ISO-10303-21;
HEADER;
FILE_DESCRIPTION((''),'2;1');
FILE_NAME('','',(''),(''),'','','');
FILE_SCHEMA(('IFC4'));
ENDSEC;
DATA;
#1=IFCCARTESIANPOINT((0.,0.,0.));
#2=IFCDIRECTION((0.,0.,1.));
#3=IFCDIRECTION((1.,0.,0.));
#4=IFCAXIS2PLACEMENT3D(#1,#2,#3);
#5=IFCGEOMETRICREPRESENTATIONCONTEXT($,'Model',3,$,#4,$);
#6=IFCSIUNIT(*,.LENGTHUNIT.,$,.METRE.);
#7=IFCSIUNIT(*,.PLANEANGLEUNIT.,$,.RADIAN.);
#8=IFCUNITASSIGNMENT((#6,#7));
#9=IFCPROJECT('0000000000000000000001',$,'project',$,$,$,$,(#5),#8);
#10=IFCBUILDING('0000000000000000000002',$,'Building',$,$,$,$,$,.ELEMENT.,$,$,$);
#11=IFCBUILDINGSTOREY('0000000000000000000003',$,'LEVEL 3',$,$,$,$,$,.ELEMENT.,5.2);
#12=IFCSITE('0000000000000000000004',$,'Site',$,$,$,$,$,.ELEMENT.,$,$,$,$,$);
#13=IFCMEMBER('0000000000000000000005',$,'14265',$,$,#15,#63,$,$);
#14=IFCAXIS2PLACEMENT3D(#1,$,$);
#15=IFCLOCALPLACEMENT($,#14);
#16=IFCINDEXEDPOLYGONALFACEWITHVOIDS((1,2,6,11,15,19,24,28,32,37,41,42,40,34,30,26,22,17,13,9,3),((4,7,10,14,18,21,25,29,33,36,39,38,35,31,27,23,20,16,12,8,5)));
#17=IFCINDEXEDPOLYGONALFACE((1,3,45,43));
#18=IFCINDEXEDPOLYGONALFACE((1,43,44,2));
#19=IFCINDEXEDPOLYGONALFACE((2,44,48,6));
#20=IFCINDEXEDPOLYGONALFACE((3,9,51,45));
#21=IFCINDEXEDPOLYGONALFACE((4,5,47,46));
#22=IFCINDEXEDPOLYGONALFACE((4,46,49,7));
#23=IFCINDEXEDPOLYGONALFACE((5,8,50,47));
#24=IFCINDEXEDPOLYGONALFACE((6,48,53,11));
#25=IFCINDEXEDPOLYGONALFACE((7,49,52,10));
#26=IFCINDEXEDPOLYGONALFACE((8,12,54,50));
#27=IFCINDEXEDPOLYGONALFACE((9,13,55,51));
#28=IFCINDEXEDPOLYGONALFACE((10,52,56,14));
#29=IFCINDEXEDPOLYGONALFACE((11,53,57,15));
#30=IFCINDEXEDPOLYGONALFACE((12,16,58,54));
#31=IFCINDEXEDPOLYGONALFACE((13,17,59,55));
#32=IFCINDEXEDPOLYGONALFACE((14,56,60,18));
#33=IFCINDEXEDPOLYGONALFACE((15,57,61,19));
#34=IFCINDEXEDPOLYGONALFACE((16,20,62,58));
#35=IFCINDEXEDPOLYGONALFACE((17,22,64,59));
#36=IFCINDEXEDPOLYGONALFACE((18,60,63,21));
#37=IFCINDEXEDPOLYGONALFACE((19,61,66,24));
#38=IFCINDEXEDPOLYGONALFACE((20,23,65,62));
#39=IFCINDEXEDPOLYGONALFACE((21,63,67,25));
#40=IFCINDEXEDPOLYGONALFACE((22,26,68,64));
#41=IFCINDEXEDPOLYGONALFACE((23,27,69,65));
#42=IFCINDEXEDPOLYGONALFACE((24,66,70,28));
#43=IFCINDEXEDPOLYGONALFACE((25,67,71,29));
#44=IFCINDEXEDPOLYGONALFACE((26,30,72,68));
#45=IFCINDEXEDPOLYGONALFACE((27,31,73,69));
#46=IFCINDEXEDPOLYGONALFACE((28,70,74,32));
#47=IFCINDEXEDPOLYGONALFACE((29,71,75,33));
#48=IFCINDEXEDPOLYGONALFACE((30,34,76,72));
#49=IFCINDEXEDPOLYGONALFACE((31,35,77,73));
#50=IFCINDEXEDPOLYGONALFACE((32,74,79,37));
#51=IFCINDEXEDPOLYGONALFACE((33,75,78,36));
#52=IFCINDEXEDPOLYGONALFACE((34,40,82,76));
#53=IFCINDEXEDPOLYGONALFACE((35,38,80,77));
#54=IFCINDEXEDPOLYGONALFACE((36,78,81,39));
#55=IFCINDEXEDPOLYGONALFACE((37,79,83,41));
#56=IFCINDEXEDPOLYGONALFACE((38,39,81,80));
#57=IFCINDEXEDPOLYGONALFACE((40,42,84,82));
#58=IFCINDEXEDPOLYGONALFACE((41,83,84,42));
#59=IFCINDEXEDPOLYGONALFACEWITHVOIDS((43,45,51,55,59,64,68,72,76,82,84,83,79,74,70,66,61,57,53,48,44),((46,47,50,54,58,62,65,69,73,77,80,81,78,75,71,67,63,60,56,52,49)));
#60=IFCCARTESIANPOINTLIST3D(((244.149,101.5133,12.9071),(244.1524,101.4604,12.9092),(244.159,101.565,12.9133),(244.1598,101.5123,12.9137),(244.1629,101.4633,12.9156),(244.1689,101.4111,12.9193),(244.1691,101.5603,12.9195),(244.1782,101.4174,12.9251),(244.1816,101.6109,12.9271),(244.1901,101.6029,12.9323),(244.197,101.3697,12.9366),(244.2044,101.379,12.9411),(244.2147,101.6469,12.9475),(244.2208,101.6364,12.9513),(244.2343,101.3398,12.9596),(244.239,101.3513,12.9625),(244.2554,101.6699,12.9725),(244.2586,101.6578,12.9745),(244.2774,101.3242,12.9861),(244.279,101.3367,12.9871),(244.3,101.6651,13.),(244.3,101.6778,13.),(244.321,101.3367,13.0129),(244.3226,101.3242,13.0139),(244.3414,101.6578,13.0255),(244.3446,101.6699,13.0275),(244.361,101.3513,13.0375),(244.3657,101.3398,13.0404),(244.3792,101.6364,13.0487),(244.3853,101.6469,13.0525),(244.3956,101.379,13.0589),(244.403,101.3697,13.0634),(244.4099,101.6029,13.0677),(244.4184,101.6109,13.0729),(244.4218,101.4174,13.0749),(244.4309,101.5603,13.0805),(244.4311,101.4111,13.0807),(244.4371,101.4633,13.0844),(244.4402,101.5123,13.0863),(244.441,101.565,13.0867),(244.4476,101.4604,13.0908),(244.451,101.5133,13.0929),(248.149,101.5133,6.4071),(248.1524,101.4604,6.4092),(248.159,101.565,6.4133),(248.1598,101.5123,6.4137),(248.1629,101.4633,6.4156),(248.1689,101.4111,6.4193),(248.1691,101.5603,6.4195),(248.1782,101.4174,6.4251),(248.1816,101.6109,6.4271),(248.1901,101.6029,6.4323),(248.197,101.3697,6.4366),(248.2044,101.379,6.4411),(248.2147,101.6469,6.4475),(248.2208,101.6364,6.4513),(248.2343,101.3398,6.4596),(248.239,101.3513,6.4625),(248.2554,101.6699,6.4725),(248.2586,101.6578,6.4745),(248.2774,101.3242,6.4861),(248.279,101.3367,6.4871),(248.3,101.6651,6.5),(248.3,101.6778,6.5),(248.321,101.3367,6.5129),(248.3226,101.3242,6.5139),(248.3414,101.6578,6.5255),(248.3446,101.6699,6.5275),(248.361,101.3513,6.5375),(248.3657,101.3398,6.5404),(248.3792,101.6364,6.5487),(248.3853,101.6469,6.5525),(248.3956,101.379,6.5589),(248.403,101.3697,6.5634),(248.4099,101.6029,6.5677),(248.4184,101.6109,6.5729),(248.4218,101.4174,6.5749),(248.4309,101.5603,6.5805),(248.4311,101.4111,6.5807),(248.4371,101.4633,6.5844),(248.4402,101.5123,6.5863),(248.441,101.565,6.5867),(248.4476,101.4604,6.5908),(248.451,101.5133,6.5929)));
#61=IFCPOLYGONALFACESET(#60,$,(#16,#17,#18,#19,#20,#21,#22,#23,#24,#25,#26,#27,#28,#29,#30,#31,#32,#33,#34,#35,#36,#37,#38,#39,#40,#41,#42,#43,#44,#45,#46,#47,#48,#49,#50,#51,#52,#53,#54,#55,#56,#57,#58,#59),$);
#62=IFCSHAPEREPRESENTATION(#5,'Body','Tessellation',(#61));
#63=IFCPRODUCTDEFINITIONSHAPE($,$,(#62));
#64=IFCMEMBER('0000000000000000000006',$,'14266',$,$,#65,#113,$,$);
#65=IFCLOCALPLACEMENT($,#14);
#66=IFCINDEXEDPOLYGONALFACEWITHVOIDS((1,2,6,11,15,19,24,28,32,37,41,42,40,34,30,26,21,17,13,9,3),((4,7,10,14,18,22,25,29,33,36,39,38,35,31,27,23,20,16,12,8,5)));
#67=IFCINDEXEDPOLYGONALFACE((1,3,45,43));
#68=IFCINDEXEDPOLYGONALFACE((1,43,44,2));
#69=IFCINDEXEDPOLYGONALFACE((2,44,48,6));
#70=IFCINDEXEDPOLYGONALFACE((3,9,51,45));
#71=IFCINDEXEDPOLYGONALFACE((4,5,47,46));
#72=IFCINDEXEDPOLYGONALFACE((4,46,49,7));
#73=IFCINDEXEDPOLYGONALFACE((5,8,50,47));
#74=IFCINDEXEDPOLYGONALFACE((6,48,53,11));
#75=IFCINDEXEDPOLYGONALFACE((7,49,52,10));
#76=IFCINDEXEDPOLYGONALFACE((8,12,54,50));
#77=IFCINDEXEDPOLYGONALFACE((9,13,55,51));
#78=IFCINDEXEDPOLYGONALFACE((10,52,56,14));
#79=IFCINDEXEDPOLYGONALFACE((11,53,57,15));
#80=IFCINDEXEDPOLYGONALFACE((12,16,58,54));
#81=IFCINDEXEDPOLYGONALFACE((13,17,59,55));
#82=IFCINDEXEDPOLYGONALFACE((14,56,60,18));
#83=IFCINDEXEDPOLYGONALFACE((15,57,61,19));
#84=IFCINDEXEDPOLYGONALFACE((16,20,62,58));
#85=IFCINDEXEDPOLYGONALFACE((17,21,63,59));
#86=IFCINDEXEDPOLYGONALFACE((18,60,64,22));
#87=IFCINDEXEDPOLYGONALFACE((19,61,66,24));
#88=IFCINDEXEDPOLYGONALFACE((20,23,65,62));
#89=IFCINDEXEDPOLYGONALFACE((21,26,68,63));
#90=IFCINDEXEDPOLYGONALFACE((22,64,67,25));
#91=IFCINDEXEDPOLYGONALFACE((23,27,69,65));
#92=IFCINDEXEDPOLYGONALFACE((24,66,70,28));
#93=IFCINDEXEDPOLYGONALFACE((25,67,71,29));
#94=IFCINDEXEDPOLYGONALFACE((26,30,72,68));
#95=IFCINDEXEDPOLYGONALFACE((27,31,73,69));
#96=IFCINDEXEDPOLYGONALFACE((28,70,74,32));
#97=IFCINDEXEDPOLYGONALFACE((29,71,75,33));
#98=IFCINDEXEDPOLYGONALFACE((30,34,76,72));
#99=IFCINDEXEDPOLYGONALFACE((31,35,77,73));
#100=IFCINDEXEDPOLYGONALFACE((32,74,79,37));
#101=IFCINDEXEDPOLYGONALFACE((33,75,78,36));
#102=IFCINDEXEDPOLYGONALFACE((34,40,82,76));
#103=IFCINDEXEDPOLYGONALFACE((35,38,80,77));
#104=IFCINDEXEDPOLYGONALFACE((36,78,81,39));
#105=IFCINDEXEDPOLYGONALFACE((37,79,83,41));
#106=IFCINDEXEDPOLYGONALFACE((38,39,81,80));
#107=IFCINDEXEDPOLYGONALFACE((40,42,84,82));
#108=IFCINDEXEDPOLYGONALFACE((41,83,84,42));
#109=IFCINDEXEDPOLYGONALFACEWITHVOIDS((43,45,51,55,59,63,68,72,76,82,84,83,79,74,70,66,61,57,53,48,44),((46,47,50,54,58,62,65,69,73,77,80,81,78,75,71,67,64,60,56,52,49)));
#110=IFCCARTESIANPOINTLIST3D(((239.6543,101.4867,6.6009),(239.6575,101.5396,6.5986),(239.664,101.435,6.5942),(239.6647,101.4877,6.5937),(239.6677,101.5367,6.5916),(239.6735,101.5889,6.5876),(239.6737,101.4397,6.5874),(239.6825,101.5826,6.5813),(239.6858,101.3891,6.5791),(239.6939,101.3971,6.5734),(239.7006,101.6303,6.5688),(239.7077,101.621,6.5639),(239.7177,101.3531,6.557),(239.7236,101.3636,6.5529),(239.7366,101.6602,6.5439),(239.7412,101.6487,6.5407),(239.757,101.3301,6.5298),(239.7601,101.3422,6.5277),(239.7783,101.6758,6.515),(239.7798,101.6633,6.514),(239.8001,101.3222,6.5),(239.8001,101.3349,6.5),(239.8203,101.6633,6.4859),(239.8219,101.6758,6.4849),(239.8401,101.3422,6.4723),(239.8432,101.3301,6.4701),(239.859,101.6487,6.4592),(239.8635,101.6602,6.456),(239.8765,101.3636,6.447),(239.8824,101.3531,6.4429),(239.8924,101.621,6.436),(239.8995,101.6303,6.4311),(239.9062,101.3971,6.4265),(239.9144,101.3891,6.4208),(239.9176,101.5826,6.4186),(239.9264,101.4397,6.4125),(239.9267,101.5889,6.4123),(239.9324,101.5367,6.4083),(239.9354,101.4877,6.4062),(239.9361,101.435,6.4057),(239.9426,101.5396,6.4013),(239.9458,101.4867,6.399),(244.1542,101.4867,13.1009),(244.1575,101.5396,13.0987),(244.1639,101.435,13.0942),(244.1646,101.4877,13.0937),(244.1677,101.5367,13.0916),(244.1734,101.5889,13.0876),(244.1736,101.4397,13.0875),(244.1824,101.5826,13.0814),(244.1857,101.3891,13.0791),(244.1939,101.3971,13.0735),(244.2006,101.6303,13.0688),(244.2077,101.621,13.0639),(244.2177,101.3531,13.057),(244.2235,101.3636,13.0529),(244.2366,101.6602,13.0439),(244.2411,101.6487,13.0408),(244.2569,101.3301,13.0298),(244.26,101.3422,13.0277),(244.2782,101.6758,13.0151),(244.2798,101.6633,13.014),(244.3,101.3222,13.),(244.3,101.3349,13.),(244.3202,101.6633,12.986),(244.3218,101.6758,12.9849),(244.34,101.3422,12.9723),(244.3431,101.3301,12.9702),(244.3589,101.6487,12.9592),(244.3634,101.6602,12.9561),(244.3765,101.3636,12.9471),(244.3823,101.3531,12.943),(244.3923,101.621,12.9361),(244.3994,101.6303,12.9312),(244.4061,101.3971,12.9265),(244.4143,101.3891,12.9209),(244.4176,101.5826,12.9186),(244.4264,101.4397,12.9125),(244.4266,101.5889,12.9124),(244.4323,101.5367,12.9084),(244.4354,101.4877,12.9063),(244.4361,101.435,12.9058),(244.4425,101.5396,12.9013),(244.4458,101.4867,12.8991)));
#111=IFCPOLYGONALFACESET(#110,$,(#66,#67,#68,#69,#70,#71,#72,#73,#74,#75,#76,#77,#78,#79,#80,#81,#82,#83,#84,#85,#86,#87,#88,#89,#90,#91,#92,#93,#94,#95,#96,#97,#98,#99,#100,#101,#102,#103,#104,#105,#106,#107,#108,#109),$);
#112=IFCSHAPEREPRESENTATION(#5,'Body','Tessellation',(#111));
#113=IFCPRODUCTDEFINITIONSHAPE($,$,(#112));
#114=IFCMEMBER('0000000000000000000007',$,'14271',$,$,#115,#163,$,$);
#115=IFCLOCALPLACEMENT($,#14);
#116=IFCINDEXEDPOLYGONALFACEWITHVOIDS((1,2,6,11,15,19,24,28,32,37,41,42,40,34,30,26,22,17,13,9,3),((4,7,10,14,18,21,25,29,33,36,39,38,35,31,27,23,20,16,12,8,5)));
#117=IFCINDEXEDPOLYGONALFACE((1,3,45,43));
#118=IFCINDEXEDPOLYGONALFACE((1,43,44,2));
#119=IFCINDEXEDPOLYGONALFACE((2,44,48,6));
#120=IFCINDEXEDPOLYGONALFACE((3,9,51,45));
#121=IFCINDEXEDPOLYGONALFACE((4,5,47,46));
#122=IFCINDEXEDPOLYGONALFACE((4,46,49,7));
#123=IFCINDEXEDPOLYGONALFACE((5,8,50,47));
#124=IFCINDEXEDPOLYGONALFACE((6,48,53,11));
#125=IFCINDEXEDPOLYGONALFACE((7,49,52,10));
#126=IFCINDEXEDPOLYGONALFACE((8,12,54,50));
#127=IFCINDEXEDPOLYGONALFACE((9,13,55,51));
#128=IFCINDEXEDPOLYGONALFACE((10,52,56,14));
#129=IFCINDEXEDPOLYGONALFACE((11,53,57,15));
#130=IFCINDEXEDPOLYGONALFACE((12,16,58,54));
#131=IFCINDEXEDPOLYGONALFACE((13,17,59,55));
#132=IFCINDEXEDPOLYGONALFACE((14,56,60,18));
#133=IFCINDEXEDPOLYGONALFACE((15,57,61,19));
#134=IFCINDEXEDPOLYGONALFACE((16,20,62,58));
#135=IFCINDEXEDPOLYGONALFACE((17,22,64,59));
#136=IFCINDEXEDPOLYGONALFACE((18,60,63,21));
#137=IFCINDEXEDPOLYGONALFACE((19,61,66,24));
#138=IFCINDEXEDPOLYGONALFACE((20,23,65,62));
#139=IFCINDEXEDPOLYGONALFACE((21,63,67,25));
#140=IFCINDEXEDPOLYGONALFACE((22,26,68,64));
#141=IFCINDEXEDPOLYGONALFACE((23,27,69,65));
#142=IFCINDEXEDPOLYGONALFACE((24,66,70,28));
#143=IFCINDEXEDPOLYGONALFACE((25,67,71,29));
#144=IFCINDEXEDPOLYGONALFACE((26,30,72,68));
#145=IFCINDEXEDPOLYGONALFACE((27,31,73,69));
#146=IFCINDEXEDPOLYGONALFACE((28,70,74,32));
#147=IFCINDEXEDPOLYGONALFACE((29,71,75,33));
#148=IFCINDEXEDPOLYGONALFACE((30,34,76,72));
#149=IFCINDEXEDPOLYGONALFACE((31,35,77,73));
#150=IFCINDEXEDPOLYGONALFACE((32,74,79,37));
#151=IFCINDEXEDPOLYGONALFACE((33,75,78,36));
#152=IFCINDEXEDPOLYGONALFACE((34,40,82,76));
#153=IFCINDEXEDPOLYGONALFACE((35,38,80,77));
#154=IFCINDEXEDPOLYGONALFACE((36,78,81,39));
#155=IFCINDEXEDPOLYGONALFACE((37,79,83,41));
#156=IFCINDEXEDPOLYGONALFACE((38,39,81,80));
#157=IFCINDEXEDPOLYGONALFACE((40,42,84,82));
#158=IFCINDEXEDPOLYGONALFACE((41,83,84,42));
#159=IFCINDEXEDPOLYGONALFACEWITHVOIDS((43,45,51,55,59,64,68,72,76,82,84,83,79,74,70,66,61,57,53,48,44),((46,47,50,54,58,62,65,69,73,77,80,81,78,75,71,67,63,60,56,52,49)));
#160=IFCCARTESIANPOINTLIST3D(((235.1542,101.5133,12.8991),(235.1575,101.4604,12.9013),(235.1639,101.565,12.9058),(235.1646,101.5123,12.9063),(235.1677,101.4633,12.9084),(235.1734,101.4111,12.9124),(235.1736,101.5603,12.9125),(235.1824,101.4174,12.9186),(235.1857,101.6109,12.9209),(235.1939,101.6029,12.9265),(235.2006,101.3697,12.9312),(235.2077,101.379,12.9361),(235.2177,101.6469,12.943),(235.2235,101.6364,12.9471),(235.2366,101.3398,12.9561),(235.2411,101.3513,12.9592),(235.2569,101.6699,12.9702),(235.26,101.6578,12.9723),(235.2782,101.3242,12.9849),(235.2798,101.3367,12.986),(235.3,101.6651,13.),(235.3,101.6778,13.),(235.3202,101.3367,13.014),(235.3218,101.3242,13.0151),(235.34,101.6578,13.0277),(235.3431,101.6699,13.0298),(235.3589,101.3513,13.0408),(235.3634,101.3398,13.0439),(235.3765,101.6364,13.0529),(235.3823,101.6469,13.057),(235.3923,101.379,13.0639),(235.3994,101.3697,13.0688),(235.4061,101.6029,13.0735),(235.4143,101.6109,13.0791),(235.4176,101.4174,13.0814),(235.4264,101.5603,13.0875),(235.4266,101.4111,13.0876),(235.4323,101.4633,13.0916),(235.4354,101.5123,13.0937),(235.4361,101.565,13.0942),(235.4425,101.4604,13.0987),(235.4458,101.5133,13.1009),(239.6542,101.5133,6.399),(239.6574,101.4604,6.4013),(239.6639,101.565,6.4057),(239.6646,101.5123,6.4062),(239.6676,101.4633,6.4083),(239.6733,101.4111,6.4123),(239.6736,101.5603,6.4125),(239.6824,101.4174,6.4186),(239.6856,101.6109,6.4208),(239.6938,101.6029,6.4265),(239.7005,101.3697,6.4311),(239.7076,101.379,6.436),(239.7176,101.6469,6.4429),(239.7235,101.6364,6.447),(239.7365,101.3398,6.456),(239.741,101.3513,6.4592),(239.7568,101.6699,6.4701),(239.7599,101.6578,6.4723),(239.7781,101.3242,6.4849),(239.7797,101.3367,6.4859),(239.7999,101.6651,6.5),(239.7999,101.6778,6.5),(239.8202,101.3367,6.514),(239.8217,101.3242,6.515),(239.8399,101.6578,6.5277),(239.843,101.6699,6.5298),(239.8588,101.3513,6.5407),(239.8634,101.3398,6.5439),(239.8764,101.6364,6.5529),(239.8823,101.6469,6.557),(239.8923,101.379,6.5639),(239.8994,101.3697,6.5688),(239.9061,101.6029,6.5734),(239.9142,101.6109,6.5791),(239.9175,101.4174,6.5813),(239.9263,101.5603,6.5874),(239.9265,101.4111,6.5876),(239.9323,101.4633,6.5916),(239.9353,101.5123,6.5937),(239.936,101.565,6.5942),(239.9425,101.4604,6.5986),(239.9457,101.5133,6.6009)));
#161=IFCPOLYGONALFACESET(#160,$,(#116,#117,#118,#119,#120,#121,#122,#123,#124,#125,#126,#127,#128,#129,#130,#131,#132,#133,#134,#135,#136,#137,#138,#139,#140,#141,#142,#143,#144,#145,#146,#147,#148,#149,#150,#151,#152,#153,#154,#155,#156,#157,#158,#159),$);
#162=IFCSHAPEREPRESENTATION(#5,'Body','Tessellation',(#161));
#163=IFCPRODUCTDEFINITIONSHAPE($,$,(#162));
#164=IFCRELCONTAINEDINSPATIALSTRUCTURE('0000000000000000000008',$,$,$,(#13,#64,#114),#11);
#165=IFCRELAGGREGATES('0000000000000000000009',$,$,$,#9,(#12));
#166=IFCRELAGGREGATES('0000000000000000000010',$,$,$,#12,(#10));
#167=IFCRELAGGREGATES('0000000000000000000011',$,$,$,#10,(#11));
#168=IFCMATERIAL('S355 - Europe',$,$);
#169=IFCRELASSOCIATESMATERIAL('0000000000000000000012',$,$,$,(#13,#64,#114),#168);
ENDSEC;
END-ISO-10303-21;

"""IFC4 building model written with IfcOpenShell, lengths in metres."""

from ifc_helpers import new_model, si_unit, frame, origin_with_axes, origin_2d_with_axis, place, context, project, spatial, hollow_circle, extrude, material, material_profile, profile_set, profile_usage, element, save


model = new_model("IFC4")

# Units and contexts
model_context = context("Model", 3, world=origin_with_axes())
ifc_project = project(units=[si_unit("LENGTHUNIT", "METRE"), si_unit("PLANEANGLEUNIT", "RADIAN")], contexts=[model_context])

# Site, building, storey
site = spatial("IfcSite", under=ifc_project, Name="Site", CompositionType="ELEMENT")
building = spatial("IfcBuilding", under=site, Name="Building", CompositionType="ELEMENT")
storey = spatial("IfcBuildingStorey", under=building, Name="LEVEL 3", CompositionType="ELEMENT", Elevation=5.2)

# Shared definitions
ifc_material = material(Name="S355 - Europe")

# Members
ifc_material_profile_1 = material_profile(ifc_material, hollow_circle(Radius=0.1778, WallThickness=0.0127, at=origin_2d_with_axis()))
ifc_profile_set_1 = profile_set([ifc_material_profile_1])
ifc_profile_usage_1 = profile_usage(ifc_profile_set_1, cardinal=10)
member_1_placement = place(None, frame((244.3, 101.5, 13.0), z_axis=(0.524097, 0.0, -0.851658), x_axis=(0.0, 1.0, 0.0)))
element("IfcMember", 1, at=member_1_placement, inside=storey, material=ifc_profile_usage_1, Name="14265", context=model_context, shape_type="SweptSolid", body=[
    extrude(hollow_circle(Radius=0.1778, WallThickness=0.0127, at=origin_2d_with_axis()), origin_with_axes(), (0.0, 0.0, 1.0), 7.6322),
])
ifc_material_profile_2 = material_profile(ifc_material, hollow_circle(Radius=0.1778, WallThickness=0.0127, at=origin_2d_with_axis()))
ifc_profile_set_2 = profile_set([ifc_material_profile_2])
ifc_profile_usage_2 = profile_usage(ifc_profile_set_2, cardinal=10)
member_2_placement = place(None, frame((244.3, 101.5, 13.0), z_axis=(-0.569201, 0.0, -0.822198), x_axis=(0.0, -1.0, 0.0)))
element("IfcMember", 2, at=member_2_placement, inside=storey, material=ifc_profile_usage_2, Name="14266", context=model_context, shape_type="SweptSolid", body=[
    extrude(hollow_circle(Radius=0.1778, WallThickness=0.0127, at=origin_2d_with_axis()), origin_with_axes(), (0.0, 0.0, 1.0), 7.9057),
])
ifc_material_profile_3 = material_profile(ifc_material, hollow_circle(Radius=0.1778, WallThickness=0.0127, at=origin_2d_with_axis()))
ifc_profile_set_3 = profile_set([ifc_material_profile_3])
ifc_profile_usage_3 = profile_usage(ifc_profile_set_3, cardinal=10)
member_3_placement = place(None, frame((235.3, 101.5, 13.0), z_axis=(0.569201, 0.0, -0.822198), x_axis=(0.0, 1.0, 0.0)))
element("IfcMember", 3, at=member_3_placement, inside=storey, material=ifc_profile_usage_3, Name="14271", context=model_context, shape_type="SweptSolid", body=[
    extrude(hollow_circle(Radius=0.1778, WallThickness=0.0127, at=origin_2d_with_axis()), origin_with_axes(), (0.0, 0.0, 1.0), 7.9057),
])

save(model, "model.ifc")
